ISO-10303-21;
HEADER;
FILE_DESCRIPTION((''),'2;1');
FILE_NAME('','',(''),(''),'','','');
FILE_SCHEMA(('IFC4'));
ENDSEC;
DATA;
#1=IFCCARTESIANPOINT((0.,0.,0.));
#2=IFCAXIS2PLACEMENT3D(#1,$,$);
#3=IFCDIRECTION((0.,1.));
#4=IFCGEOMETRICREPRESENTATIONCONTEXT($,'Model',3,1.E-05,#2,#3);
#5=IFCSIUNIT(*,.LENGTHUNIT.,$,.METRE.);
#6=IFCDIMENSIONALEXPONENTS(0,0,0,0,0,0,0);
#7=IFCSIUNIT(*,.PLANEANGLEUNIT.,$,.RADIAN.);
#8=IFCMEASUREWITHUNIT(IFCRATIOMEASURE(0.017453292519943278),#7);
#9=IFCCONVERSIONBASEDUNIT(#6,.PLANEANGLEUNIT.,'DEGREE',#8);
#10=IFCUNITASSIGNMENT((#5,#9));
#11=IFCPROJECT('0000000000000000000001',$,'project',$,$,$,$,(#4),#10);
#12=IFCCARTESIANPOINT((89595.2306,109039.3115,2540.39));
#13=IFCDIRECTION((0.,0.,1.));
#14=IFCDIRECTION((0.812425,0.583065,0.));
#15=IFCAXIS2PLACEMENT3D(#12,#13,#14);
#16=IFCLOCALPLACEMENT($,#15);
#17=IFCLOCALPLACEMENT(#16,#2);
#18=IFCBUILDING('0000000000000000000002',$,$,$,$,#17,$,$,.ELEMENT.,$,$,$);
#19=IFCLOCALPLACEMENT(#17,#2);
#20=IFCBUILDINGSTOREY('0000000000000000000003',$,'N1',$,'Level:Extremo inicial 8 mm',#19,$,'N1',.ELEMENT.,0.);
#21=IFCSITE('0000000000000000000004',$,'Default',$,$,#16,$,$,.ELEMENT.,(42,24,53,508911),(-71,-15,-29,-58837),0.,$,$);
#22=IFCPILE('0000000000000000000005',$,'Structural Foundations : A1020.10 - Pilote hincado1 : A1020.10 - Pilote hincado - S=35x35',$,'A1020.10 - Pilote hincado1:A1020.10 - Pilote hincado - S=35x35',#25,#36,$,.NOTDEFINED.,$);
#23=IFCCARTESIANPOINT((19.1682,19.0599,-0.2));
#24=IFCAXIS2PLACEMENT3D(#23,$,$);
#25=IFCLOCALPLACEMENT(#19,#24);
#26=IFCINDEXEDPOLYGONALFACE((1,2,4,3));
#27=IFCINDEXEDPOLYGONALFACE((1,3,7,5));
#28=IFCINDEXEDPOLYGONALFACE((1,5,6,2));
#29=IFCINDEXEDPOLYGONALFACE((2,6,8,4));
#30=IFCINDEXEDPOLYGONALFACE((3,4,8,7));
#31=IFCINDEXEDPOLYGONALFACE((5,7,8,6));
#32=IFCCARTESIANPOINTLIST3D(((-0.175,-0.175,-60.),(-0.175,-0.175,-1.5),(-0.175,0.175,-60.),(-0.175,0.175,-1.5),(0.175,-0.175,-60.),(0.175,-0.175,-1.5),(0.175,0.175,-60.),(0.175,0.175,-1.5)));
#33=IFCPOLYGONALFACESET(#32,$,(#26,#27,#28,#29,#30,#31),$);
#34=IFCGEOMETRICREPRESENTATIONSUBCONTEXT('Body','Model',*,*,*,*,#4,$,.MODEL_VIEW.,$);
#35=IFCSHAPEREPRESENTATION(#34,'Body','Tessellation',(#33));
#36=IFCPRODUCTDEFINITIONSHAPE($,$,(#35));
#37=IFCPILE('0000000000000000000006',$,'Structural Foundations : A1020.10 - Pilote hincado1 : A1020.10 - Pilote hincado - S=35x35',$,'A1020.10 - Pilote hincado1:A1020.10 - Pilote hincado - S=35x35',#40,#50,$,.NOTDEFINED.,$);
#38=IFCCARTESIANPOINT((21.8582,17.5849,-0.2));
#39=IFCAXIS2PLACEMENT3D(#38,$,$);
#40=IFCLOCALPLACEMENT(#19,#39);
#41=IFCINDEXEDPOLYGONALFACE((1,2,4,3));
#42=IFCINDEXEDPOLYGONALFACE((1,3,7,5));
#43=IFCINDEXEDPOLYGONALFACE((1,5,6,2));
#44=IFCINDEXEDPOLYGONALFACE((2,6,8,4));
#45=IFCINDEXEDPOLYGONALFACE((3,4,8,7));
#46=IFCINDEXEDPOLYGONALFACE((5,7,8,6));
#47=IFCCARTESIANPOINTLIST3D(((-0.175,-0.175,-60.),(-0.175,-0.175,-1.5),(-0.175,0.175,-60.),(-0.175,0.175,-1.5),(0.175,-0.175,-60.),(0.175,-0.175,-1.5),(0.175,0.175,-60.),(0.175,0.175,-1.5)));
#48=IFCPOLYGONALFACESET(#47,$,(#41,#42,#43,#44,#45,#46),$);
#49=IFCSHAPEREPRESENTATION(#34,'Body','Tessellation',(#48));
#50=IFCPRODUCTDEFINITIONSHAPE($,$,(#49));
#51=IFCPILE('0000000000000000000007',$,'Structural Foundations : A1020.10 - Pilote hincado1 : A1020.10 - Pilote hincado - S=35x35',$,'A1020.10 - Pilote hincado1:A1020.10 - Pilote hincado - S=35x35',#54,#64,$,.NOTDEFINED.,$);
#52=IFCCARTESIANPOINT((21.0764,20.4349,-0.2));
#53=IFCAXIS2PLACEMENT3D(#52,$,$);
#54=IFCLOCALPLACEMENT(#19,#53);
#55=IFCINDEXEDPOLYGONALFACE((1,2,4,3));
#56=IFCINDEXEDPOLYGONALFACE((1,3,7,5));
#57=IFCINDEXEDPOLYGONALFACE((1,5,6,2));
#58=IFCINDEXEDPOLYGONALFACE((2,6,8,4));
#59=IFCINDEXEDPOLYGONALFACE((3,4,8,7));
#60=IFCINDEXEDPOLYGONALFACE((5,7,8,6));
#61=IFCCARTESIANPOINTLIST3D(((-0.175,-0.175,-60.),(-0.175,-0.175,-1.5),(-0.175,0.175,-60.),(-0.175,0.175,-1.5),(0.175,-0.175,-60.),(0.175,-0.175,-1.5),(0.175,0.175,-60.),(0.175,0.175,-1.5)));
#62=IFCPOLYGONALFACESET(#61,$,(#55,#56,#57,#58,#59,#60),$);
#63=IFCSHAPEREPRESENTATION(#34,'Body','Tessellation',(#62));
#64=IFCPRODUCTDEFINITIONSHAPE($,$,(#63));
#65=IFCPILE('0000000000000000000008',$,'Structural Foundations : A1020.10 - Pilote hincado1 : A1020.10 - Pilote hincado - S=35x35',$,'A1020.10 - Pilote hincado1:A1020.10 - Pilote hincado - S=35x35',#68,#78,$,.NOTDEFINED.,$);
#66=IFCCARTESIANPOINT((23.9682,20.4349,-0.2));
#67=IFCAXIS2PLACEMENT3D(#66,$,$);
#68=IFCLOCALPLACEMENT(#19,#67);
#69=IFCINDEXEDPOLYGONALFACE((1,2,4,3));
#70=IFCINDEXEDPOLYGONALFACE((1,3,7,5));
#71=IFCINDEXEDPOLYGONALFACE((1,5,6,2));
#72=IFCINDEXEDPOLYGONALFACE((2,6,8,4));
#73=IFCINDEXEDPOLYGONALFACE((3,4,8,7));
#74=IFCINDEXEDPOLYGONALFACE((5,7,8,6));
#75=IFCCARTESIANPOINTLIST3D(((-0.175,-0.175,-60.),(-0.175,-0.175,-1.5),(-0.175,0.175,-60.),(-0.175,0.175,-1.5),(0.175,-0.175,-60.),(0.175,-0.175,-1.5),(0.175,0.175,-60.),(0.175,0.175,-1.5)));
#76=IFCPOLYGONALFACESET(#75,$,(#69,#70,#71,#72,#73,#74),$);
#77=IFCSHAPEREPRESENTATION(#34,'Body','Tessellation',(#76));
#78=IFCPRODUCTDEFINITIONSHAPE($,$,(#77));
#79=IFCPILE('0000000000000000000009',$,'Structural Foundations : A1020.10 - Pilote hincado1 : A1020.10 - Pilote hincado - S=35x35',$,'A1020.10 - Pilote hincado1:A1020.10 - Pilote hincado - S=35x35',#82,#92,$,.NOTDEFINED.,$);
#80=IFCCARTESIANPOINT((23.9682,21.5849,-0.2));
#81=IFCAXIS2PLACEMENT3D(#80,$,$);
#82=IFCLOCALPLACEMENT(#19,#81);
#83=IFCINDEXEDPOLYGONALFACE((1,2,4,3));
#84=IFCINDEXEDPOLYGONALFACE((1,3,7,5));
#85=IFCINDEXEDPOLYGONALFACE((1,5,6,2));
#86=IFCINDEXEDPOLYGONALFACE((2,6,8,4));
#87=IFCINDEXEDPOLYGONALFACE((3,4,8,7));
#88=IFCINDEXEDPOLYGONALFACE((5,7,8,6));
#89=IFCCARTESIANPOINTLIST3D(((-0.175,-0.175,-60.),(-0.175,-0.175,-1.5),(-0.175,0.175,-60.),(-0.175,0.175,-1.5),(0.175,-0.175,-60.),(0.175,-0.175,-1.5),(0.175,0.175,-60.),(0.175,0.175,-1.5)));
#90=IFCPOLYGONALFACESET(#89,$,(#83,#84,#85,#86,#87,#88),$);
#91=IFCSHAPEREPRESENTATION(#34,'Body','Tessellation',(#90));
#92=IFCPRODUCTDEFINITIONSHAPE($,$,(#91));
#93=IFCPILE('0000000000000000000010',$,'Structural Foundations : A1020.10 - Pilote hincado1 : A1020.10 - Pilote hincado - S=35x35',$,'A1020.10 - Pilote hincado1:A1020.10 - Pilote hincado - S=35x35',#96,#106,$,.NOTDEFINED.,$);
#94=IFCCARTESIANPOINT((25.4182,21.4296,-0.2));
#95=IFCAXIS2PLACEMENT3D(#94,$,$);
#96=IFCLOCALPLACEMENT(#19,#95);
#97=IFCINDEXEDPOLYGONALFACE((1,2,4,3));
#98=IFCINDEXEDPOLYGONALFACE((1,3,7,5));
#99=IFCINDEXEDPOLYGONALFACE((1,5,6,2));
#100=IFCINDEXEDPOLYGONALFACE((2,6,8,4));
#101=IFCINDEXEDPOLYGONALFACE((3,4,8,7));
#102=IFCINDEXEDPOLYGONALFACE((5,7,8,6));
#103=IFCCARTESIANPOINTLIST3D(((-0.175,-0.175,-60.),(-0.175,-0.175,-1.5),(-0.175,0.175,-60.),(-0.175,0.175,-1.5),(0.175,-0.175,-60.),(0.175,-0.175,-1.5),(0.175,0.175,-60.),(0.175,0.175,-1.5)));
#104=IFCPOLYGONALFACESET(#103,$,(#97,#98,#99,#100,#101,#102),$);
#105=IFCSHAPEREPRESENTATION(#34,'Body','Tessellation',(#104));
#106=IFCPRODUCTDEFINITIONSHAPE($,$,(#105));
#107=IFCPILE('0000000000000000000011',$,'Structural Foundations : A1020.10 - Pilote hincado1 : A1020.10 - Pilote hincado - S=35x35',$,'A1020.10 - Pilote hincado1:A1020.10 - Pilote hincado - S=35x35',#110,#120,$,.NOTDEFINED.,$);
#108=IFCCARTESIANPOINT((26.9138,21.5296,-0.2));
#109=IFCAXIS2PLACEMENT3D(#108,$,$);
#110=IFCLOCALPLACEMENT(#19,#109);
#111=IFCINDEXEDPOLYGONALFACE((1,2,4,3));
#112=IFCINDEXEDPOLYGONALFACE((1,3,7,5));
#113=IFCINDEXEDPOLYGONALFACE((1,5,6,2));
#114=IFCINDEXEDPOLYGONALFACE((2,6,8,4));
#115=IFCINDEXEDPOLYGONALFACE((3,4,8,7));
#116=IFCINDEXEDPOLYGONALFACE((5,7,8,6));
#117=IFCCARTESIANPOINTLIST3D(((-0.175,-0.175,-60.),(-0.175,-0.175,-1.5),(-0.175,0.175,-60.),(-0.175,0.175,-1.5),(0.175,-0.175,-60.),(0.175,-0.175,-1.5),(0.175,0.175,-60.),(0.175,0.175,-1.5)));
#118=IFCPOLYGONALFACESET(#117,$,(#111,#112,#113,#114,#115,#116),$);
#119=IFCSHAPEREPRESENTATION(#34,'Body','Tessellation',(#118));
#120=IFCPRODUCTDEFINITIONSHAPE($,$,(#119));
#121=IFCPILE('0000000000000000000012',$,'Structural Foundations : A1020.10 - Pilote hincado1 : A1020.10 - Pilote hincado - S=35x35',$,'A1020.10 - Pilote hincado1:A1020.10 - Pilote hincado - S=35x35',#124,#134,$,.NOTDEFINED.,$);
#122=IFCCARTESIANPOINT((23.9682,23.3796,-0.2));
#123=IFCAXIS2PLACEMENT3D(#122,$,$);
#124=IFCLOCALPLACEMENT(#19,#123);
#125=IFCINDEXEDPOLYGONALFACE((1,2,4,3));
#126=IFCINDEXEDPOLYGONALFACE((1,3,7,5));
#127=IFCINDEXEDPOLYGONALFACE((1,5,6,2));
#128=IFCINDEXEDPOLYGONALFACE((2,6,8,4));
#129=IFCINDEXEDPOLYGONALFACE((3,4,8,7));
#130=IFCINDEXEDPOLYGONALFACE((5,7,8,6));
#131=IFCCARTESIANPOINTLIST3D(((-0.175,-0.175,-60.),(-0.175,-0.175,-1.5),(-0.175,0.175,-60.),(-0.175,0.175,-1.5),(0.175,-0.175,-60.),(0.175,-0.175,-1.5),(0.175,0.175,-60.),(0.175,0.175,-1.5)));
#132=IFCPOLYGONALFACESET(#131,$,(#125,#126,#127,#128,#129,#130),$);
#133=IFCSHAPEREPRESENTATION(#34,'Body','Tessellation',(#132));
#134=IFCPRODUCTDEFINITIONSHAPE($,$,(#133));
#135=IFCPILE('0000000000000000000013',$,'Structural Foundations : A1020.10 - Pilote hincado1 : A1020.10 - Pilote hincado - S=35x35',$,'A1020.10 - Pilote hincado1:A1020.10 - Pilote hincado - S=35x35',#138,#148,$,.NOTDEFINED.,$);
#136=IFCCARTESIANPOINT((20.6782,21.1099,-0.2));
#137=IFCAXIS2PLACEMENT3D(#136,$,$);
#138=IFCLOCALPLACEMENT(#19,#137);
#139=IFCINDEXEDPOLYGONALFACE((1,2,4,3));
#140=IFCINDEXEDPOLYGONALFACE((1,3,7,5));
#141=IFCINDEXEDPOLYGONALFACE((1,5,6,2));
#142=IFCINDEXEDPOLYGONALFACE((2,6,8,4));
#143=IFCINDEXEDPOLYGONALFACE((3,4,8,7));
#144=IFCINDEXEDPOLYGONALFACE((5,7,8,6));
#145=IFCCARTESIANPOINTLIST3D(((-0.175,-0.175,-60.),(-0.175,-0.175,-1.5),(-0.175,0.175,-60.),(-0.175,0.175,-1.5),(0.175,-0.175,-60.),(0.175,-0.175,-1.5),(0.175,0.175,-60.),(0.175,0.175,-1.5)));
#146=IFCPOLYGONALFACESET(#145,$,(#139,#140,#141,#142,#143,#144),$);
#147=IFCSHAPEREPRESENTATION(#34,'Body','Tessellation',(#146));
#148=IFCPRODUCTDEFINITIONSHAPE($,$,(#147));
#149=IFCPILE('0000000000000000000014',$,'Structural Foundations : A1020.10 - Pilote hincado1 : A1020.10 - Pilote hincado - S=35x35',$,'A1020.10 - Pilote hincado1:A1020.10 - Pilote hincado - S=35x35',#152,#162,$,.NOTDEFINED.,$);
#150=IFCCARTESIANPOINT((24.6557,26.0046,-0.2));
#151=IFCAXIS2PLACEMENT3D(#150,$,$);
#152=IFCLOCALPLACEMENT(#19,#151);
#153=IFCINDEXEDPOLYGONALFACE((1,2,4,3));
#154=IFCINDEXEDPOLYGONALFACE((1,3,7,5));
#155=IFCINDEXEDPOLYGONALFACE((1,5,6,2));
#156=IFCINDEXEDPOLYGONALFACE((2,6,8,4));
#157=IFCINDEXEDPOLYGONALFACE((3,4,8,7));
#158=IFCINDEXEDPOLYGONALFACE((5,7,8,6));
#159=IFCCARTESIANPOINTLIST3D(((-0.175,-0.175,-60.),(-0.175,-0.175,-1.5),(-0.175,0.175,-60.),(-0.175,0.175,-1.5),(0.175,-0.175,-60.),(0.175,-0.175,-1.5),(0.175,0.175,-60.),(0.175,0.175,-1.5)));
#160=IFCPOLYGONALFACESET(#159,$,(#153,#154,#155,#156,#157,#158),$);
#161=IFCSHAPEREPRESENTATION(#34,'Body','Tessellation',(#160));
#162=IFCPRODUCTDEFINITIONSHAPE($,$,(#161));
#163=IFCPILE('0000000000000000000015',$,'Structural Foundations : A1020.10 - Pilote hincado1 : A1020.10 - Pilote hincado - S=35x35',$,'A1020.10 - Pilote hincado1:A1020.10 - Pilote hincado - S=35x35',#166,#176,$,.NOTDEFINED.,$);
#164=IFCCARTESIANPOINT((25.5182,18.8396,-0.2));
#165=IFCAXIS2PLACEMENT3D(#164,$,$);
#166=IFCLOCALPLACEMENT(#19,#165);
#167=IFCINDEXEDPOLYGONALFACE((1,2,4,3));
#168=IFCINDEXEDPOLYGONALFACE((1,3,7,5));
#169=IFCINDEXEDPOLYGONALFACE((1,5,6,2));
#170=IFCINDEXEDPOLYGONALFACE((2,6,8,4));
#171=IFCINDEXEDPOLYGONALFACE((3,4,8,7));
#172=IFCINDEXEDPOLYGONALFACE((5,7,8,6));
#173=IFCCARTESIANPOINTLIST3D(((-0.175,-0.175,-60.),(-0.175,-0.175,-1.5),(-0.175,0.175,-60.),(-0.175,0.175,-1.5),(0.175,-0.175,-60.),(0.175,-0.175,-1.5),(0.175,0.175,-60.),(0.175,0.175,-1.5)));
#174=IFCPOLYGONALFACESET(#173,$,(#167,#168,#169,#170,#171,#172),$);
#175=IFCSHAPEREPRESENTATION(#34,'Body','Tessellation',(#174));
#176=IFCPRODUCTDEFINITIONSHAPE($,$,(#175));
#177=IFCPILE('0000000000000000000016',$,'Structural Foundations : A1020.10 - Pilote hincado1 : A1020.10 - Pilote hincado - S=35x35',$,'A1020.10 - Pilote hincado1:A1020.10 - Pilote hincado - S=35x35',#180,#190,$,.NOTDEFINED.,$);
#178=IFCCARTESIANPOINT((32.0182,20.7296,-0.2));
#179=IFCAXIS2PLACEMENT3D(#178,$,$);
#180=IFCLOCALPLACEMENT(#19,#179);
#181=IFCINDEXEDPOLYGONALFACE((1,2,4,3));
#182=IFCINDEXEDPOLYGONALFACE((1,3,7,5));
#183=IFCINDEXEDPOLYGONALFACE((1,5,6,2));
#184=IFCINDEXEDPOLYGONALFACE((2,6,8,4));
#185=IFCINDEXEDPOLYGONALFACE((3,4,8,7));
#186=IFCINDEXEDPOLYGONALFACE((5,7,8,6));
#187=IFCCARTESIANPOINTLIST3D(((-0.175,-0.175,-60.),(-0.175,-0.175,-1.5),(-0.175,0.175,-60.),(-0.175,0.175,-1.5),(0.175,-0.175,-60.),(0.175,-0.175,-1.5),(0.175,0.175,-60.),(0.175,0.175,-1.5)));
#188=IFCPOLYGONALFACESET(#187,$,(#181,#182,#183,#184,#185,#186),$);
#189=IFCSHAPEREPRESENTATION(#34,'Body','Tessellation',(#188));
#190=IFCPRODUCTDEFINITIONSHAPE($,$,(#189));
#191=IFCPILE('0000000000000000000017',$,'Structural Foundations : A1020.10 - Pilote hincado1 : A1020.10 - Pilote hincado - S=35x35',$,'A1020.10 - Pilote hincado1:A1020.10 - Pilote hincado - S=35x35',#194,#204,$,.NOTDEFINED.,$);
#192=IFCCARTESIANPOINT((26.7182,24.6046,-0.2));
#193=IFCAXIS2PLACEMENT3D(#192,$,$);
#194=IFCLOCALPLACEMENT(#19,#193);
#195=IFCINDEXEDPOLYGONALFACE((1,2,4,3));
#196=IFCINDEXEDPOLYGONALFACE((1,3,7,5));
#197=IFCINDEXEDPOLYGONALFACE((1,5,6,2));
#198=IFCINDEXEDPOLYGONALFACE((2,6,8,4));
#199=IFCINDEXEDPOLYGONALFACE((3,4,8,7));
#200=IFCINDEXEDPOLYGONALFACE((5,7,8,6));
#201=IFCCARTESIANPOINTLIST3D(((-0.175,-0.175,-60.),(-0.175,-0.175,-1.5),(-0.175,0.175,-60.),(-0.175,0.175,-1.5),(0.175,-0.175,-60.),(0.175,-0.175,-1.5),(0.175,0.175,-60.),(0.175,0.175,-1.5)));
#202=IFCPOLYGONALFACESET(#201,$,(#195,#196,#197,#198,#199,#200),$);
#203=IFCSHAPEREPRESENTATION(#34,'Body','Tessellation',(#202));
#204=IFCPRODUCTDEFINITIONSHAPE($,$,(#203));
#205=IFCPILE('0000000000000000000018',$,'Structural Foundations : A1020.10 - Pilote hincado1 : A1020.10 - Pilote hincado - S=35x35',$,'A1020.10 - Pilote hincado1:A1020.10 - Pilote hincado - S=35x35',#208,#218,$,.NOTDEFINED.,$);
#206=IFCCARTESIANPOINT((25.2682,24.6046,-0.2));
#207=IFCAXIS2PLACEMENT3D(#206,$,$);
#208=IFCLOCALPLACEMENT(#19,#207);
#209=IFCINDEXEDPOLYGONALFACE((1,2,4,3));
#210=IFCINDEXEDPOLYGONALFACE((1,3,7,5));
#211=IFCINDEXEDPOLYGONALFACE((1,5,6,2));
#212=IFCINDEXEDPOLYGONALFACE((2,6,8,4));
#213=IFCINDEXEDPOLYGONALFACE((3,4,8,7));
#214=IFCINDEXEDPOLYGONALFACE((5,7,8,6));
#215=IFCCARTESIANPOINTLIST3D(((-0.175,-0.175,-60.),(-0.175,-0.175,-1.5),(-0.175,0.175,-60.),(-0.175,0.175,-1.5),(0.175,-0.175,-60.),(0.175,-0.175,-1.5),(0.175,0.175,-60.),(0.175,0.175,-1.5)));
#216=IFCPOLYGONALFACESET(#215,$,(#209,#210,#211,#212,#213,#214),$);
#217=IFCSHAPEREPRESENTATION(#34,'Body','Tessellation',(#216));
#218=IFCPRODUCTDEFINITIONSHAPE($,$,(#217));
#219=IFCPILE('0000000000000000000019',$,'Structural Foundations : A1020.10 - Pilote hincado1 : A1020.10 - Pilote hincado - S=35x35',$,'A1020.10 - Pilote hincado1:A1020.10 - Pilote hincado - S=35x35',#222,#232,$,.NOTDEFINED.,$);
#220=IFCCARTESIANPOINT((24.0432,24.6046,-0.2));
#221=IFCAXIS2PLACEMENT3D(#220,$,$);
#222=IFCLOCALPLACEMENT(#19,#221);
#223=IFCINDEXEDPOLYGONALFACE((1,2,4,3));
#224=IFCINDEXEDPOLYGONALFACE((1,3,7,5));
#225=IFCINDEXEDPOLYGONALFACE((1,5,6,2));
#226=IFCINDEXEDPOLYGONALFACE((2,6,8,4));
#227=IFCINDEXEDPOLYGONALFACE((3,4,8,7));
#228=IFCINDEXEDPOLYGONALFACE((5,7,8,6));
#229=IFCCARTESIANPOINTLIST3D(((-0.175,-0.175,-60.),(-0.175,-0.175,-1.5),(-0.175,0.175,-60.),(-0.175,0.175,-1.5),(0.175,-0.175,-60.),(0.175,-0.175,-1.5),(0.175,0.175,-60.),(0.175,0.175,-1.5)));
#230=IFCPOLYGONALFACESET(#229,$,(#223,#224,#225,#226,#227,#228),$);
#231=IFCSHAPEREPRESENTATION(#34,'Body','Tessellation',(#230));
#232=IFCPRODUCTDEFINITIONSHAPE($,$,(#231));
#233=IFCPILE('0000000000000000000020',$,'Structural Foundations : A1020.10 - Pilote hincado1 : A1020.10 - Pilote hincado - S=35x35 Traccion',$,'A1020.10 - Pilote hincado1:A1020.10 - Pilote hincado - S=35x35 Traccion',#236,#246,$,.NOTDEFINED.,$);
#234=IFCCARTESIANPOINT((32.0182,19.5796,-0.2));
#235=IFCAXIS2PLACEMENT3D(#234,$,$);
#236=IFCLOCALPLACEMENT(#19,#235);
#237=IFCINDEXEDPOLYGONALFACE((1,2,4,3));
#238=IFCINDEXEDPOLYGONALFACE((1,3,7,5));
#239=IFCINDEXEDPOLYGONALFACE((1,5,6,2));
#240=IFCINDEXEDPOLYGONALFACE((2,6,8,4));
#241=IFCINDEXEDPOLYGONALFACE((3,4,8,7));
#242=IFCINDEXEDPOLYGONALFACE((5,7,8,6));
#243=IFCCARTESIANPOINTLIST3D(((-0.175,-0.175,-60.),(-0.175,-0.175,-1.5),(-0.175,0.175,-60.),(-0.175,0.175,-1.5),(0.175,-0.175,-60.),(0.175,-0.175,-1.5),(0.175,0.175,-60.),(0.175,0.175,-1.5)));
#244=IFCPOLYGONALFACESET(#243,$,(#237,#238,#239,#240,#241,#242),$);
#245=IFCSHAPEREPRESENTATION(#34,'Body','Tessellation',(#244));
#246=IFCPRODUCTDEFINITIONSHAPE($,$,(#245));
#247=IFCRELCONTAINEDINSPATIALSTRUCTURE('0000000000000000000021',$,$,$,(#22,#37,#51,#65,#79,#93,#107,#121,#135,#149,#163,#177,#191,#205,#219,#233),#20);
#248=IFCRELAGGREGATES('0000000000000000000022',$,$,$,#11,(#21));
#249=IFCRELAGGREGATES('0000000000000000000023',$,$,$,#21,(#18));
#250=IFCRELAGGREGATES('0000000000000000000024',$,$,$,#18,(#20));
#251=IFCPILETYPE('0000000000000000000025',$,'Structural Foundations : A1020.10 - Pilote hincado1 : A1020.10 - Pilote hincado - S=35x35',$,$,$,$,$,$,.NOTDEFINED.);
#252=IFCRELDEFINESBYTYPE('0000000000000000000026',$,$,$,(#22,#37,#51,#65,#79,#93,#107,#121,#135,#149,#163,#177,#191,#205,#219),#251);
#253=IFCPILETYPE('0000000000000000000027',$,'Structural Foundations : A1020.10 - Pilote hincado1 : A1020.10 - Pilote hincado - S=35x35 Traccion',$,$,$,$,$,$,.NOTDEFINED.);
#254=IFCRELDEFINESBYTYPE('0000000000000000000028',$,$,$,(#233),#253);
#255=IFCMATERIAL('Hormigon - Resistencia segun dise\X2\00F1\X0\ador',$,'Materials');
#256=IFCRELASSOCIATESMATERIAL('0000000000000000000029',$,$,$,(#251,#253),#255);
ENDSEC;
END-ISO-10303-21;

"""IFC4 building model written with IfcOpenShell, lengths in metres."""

from ifc_helpers import new_model, entity, si_unit, converted_unit, direction, frame, origin, origin_2d_with_axis, place, context, subcontext, project, spatial, polyline, segment, composite_curve, rectangle, outline, extrude, source, transform, mapped, material, material_profile, profile_set, type_object, type_shapes, element, save


model = new_model("IFC4")

# Units and contexts
model_context = context("Model", 3, precision=1e-05, world=origin(), true_north=direction((0.0, 1.0)))
body_context = subcontext(model_context, "Body", "Model", "MODEL_VIEW")
ifc_project = project(units=[si_unit("LENGTHUNIT", "METRE"), converted_unit("PLANEANGLEUNIT", "DEGREE", entity("IfcRatioMeasure", 0.017453292519943278), si_unit("PLANEANGLEUNIT", "RADIAN"), dimensions=[0, 0, 0, 0, 0, 0, 0])], contexts=[model_context])

# Site, building, storey
site_placement = place(None, frame((89595.2306, 109039.3115, 2540.39), z_axis=(0.0, 0.0, 1.0), x_axis=(0.812425, 0.583065, 0.0)))
site = spatial("IfcSite", under=ifc_project, at=site_placement, Name="Default", CompositionType="ELEMENT", RefLatitude=(42, 24, 53, 508911), RefLongitude=(-71, -15, -29, -58837), RefElevation=0.0)
building_placement = place(site_placement, origin())
building = spatial("IfcBuilding", under=site, at=building_placement, CompositionType="ELEMENT")
storey_placement = place(building_placement, origin())
storey = spatial("IfcBuildingStorey", under=building, at=storey_placement, Name="N1", ObjectType="Level:Extremo inicial 8 mm", LongName="N1", CompositionType="ELEMENT", Elevation=0.0)

# Piles
ifc_material_1 = material(Name="Hormigon - Resistencia segun diseñador", Category="Materials")
ifc_material_profile_1 = material_profile(ifc_material_1, outline(composite_curve([segment(polyline([(0.175, -0.175, -60.0), (-0.175, -0.175, -60.0)]), True, "CONTINUOUS"), segment(polyline([(-0.175, -0.175, -60.0), (-0.175, 0.175, -60.0)]), True, "CONTINUOUS"), segment(polyline([(-0.175, 0.175, -60.0), (0.175, 0.175, -60.0)]), True, "CONTINUOUS"), segment(polyline([(0.175, 0.175, -60.0), (0.175, -0.175, -60.0)]), True, "CONTINUOUS")], self_intersect=False), kind="CURVE"), Name="A1020.10 - Pilote hincado - S=35x35")
ifc_profile_set_1 = profile_set([ifc_material_profile_1], Name="A1020.10 - Pilote hincado - S=35x35")
pile_type_1 = type_object("IfcPileType", Name="Structural Foundations : A1020.10 - Pilote hincado1 : A1020.10 - Pilote hincado - S=35x35", PredefinedType="NOTDEFINED", material=ifc_profile_set_1)
shared_shape_1 = source(origin(), body_context, "Body", "SweptSolid", [
    extrude(rectangle(XDim=0.35, YDim=0.35, at=origin_2d_with_axis()), frame((0.0, 0.0, -60.0), z_axis=(0.0, 0.0, 1.0), x_axis=(0.0, -1.0, 0.0)), (0.0, 0.0, 1.0), 58.5),
])
type_shapes(pile_type_1, [shared_shape_1])
for number, where, name in (
    (1, (19.1682, 19.0599, -0.2), "Structural Foundations : A1020.10 - Pilote hincado1 : A1020.10 - Pilote hincado - S=35x35"),
    (2, (21.8582, 17.5849, -0.2), "Structural Foundations : A1020.10 - Pilote hincado1 : A1020.10 - Pilote hincado - S=35x35"),
    (3, (21.0764, 20.4349, -0.2), "Structural Foundations : A1020.10 - Pilote hincado1 : A1020.10 - Pilote hincado - S=35x35"),
    (4, (23.9682, 20.4349, -0.2), "Structural Foundations : A1020.10 - Pilote hincado1 : A1020.10 - Pilote hincado - S=35x35"),
    (5, (23.9682, 21.5849, -0.2), "Structural Foundations : A1020.10 - Pilote hincado1 : A1020.10 - Pilote hincado - S=35x35"),
    (6, (25.4182, 21.4296, -0.2), "Structural Foundations : A1020.10 - Pilote hincado1 : A1020.10 - Pilote hincado - S=35x35"),
    (7, (26.9138, 21.5296, -0.2), "Structural Foundations : A1020.10 - Pilote hincado1 : A1020.10 - Pilote hincado - S=35x35"),
    (8, (23.9682, 23.3796, -0.2), "Structural Foundations : A1020.10 - Pilote hincado1 : A1020.10 - Pilote hincado - S=35x35"),
    (9, (20.6782, 21.1099, -0.2), "Structural Foundations : A1020.10 - Pilote hincado1 : A1020.10 - Pilote hincado - S=35x35"),
    (10, (24.6557, 26.0046, -0.2), "Structural Foundations : A1020.10 - Pilote hincado1 : A1020.10 - Pilote hincado - S=35x35"),
    (11, (25.5182, 18.8396, -0.2), "Structural Foundations : A1020.10 - Pilote hincado1 : A1020.10 - Pilote hincado - S=35x35"),
    (12, (32.0182, 20.7296, -0.2), "Structural Foundations : A1020.10 - Pilote hincado1 : A1020.10 - Pilote hincado - S=35x35"),
    (13, (26.7182, 24.6046, -0.2), "Structural Foundations : A1020.10 - Pilote hincado1 : A1020.10 - Pilote hincado - S=35x35"),
    (14, (25.2682, 24.6046, -0.2), "Structural Foundations : A1020.10 - Pilote hincado1 : A1020.10 - Pilote hincado - S=35x35"),
    (15, (24.0432, 24.6046, -0.2), "Structural Foundations : A1020.10 - Pilote hincado1 : A1020.10 - Pilote hincado - S=35x35"),
):
    element("IfcPile", number, at=place(storey_placement, frame(where)), inside=storey, type_object=pile_type_1, Name=name, ObjectType="A1020.10 - Pilote hincado1:A1020.10 - Pilote hincado - S=35x35", PredefinedType="NOTDEFINED", context=body_context, shape_type="MappedRepresentation", body=[
        mapped(shared_shape_1, transform((0.0, 0.0, 0.0), scale=1.0)),
    ])
ifc_material_profile_2 = material_profile(ifc_material_1, outline(composite_curve([segment(polyline([(0.175, -0.175, -60.0), (-0.175, -0.175, -60.0)]), True, "CONTINUOUS"), segment(polyline([(-0.175, -0.175, -60.0), (-0.175, 0.175, -60.0)]), True, "CONTINUOUS"), segment(polyline([(-0.175, 0.175, -60.0), (0.175, 0.175, -60.0)]), True, "CONTINUOUS"), segment(polyline([(0.175, 0.175, -60.0), (0.175, -0.175, -60.0)]), True, "CONTINUOUS")], self_intersect=False), kind="CURVE"), Name="A1020.10 - Pilote hincado - S=35x35 Traccion")
ifc_profile_set_2 = profile_set([ifc_material_profile_2], Name="A1020.10 - Pilote hincado - S=35x35 Traccion")
pile_type_2 = type_object("IfcPileType", Name="Structural Foundations : A1020.10 - Pilote hincado1 : A1020.10 - Pilote hincado - S=35x35 Traccion", PredefinedType="NOTDEFINED", material=ifc_profile_set_2)
shared_shape_2 = source(origin(), body_context, "Body", "SweptSolid", [
    extrude(rectangle(XDim=0.35, YDim=0.35, at=origin_2d_with_axis()), frame((0.0, 0.0, -60.0), z_axis=(0.0, 0.0, 1.0), x_axis=(0.0, -1.0, 0.0)), (0.0, 0.0, 1.0), 58.5),
])
type_shapes(pile_type_2, [shared_shape_2])
pile_1_placement = place(storey_placement, frame((32.0182, 19.5796, -0.2)))
element("IfcPile", 16, at=pile_1_placement, inside=storey, type_object=pile_type_2, Name="Structural Foundations : A1020.10 - Pilote hincado1 : A1020.10 - Pilote hincado - S=35x35 Traccion", ObjectType="A1020.10 - Pilote hincado1:A1020.10 - Pilote hincado - S=35x35 Traccion", PredefinedType="NOTDEFINED", context=body_context, shape_type="MappedRepresentation", body=[
    mapped(shared_shape_2, transform((0.0, 0.0, 0.0), scale=1.0)),
])

save(model, "model.ifc")
